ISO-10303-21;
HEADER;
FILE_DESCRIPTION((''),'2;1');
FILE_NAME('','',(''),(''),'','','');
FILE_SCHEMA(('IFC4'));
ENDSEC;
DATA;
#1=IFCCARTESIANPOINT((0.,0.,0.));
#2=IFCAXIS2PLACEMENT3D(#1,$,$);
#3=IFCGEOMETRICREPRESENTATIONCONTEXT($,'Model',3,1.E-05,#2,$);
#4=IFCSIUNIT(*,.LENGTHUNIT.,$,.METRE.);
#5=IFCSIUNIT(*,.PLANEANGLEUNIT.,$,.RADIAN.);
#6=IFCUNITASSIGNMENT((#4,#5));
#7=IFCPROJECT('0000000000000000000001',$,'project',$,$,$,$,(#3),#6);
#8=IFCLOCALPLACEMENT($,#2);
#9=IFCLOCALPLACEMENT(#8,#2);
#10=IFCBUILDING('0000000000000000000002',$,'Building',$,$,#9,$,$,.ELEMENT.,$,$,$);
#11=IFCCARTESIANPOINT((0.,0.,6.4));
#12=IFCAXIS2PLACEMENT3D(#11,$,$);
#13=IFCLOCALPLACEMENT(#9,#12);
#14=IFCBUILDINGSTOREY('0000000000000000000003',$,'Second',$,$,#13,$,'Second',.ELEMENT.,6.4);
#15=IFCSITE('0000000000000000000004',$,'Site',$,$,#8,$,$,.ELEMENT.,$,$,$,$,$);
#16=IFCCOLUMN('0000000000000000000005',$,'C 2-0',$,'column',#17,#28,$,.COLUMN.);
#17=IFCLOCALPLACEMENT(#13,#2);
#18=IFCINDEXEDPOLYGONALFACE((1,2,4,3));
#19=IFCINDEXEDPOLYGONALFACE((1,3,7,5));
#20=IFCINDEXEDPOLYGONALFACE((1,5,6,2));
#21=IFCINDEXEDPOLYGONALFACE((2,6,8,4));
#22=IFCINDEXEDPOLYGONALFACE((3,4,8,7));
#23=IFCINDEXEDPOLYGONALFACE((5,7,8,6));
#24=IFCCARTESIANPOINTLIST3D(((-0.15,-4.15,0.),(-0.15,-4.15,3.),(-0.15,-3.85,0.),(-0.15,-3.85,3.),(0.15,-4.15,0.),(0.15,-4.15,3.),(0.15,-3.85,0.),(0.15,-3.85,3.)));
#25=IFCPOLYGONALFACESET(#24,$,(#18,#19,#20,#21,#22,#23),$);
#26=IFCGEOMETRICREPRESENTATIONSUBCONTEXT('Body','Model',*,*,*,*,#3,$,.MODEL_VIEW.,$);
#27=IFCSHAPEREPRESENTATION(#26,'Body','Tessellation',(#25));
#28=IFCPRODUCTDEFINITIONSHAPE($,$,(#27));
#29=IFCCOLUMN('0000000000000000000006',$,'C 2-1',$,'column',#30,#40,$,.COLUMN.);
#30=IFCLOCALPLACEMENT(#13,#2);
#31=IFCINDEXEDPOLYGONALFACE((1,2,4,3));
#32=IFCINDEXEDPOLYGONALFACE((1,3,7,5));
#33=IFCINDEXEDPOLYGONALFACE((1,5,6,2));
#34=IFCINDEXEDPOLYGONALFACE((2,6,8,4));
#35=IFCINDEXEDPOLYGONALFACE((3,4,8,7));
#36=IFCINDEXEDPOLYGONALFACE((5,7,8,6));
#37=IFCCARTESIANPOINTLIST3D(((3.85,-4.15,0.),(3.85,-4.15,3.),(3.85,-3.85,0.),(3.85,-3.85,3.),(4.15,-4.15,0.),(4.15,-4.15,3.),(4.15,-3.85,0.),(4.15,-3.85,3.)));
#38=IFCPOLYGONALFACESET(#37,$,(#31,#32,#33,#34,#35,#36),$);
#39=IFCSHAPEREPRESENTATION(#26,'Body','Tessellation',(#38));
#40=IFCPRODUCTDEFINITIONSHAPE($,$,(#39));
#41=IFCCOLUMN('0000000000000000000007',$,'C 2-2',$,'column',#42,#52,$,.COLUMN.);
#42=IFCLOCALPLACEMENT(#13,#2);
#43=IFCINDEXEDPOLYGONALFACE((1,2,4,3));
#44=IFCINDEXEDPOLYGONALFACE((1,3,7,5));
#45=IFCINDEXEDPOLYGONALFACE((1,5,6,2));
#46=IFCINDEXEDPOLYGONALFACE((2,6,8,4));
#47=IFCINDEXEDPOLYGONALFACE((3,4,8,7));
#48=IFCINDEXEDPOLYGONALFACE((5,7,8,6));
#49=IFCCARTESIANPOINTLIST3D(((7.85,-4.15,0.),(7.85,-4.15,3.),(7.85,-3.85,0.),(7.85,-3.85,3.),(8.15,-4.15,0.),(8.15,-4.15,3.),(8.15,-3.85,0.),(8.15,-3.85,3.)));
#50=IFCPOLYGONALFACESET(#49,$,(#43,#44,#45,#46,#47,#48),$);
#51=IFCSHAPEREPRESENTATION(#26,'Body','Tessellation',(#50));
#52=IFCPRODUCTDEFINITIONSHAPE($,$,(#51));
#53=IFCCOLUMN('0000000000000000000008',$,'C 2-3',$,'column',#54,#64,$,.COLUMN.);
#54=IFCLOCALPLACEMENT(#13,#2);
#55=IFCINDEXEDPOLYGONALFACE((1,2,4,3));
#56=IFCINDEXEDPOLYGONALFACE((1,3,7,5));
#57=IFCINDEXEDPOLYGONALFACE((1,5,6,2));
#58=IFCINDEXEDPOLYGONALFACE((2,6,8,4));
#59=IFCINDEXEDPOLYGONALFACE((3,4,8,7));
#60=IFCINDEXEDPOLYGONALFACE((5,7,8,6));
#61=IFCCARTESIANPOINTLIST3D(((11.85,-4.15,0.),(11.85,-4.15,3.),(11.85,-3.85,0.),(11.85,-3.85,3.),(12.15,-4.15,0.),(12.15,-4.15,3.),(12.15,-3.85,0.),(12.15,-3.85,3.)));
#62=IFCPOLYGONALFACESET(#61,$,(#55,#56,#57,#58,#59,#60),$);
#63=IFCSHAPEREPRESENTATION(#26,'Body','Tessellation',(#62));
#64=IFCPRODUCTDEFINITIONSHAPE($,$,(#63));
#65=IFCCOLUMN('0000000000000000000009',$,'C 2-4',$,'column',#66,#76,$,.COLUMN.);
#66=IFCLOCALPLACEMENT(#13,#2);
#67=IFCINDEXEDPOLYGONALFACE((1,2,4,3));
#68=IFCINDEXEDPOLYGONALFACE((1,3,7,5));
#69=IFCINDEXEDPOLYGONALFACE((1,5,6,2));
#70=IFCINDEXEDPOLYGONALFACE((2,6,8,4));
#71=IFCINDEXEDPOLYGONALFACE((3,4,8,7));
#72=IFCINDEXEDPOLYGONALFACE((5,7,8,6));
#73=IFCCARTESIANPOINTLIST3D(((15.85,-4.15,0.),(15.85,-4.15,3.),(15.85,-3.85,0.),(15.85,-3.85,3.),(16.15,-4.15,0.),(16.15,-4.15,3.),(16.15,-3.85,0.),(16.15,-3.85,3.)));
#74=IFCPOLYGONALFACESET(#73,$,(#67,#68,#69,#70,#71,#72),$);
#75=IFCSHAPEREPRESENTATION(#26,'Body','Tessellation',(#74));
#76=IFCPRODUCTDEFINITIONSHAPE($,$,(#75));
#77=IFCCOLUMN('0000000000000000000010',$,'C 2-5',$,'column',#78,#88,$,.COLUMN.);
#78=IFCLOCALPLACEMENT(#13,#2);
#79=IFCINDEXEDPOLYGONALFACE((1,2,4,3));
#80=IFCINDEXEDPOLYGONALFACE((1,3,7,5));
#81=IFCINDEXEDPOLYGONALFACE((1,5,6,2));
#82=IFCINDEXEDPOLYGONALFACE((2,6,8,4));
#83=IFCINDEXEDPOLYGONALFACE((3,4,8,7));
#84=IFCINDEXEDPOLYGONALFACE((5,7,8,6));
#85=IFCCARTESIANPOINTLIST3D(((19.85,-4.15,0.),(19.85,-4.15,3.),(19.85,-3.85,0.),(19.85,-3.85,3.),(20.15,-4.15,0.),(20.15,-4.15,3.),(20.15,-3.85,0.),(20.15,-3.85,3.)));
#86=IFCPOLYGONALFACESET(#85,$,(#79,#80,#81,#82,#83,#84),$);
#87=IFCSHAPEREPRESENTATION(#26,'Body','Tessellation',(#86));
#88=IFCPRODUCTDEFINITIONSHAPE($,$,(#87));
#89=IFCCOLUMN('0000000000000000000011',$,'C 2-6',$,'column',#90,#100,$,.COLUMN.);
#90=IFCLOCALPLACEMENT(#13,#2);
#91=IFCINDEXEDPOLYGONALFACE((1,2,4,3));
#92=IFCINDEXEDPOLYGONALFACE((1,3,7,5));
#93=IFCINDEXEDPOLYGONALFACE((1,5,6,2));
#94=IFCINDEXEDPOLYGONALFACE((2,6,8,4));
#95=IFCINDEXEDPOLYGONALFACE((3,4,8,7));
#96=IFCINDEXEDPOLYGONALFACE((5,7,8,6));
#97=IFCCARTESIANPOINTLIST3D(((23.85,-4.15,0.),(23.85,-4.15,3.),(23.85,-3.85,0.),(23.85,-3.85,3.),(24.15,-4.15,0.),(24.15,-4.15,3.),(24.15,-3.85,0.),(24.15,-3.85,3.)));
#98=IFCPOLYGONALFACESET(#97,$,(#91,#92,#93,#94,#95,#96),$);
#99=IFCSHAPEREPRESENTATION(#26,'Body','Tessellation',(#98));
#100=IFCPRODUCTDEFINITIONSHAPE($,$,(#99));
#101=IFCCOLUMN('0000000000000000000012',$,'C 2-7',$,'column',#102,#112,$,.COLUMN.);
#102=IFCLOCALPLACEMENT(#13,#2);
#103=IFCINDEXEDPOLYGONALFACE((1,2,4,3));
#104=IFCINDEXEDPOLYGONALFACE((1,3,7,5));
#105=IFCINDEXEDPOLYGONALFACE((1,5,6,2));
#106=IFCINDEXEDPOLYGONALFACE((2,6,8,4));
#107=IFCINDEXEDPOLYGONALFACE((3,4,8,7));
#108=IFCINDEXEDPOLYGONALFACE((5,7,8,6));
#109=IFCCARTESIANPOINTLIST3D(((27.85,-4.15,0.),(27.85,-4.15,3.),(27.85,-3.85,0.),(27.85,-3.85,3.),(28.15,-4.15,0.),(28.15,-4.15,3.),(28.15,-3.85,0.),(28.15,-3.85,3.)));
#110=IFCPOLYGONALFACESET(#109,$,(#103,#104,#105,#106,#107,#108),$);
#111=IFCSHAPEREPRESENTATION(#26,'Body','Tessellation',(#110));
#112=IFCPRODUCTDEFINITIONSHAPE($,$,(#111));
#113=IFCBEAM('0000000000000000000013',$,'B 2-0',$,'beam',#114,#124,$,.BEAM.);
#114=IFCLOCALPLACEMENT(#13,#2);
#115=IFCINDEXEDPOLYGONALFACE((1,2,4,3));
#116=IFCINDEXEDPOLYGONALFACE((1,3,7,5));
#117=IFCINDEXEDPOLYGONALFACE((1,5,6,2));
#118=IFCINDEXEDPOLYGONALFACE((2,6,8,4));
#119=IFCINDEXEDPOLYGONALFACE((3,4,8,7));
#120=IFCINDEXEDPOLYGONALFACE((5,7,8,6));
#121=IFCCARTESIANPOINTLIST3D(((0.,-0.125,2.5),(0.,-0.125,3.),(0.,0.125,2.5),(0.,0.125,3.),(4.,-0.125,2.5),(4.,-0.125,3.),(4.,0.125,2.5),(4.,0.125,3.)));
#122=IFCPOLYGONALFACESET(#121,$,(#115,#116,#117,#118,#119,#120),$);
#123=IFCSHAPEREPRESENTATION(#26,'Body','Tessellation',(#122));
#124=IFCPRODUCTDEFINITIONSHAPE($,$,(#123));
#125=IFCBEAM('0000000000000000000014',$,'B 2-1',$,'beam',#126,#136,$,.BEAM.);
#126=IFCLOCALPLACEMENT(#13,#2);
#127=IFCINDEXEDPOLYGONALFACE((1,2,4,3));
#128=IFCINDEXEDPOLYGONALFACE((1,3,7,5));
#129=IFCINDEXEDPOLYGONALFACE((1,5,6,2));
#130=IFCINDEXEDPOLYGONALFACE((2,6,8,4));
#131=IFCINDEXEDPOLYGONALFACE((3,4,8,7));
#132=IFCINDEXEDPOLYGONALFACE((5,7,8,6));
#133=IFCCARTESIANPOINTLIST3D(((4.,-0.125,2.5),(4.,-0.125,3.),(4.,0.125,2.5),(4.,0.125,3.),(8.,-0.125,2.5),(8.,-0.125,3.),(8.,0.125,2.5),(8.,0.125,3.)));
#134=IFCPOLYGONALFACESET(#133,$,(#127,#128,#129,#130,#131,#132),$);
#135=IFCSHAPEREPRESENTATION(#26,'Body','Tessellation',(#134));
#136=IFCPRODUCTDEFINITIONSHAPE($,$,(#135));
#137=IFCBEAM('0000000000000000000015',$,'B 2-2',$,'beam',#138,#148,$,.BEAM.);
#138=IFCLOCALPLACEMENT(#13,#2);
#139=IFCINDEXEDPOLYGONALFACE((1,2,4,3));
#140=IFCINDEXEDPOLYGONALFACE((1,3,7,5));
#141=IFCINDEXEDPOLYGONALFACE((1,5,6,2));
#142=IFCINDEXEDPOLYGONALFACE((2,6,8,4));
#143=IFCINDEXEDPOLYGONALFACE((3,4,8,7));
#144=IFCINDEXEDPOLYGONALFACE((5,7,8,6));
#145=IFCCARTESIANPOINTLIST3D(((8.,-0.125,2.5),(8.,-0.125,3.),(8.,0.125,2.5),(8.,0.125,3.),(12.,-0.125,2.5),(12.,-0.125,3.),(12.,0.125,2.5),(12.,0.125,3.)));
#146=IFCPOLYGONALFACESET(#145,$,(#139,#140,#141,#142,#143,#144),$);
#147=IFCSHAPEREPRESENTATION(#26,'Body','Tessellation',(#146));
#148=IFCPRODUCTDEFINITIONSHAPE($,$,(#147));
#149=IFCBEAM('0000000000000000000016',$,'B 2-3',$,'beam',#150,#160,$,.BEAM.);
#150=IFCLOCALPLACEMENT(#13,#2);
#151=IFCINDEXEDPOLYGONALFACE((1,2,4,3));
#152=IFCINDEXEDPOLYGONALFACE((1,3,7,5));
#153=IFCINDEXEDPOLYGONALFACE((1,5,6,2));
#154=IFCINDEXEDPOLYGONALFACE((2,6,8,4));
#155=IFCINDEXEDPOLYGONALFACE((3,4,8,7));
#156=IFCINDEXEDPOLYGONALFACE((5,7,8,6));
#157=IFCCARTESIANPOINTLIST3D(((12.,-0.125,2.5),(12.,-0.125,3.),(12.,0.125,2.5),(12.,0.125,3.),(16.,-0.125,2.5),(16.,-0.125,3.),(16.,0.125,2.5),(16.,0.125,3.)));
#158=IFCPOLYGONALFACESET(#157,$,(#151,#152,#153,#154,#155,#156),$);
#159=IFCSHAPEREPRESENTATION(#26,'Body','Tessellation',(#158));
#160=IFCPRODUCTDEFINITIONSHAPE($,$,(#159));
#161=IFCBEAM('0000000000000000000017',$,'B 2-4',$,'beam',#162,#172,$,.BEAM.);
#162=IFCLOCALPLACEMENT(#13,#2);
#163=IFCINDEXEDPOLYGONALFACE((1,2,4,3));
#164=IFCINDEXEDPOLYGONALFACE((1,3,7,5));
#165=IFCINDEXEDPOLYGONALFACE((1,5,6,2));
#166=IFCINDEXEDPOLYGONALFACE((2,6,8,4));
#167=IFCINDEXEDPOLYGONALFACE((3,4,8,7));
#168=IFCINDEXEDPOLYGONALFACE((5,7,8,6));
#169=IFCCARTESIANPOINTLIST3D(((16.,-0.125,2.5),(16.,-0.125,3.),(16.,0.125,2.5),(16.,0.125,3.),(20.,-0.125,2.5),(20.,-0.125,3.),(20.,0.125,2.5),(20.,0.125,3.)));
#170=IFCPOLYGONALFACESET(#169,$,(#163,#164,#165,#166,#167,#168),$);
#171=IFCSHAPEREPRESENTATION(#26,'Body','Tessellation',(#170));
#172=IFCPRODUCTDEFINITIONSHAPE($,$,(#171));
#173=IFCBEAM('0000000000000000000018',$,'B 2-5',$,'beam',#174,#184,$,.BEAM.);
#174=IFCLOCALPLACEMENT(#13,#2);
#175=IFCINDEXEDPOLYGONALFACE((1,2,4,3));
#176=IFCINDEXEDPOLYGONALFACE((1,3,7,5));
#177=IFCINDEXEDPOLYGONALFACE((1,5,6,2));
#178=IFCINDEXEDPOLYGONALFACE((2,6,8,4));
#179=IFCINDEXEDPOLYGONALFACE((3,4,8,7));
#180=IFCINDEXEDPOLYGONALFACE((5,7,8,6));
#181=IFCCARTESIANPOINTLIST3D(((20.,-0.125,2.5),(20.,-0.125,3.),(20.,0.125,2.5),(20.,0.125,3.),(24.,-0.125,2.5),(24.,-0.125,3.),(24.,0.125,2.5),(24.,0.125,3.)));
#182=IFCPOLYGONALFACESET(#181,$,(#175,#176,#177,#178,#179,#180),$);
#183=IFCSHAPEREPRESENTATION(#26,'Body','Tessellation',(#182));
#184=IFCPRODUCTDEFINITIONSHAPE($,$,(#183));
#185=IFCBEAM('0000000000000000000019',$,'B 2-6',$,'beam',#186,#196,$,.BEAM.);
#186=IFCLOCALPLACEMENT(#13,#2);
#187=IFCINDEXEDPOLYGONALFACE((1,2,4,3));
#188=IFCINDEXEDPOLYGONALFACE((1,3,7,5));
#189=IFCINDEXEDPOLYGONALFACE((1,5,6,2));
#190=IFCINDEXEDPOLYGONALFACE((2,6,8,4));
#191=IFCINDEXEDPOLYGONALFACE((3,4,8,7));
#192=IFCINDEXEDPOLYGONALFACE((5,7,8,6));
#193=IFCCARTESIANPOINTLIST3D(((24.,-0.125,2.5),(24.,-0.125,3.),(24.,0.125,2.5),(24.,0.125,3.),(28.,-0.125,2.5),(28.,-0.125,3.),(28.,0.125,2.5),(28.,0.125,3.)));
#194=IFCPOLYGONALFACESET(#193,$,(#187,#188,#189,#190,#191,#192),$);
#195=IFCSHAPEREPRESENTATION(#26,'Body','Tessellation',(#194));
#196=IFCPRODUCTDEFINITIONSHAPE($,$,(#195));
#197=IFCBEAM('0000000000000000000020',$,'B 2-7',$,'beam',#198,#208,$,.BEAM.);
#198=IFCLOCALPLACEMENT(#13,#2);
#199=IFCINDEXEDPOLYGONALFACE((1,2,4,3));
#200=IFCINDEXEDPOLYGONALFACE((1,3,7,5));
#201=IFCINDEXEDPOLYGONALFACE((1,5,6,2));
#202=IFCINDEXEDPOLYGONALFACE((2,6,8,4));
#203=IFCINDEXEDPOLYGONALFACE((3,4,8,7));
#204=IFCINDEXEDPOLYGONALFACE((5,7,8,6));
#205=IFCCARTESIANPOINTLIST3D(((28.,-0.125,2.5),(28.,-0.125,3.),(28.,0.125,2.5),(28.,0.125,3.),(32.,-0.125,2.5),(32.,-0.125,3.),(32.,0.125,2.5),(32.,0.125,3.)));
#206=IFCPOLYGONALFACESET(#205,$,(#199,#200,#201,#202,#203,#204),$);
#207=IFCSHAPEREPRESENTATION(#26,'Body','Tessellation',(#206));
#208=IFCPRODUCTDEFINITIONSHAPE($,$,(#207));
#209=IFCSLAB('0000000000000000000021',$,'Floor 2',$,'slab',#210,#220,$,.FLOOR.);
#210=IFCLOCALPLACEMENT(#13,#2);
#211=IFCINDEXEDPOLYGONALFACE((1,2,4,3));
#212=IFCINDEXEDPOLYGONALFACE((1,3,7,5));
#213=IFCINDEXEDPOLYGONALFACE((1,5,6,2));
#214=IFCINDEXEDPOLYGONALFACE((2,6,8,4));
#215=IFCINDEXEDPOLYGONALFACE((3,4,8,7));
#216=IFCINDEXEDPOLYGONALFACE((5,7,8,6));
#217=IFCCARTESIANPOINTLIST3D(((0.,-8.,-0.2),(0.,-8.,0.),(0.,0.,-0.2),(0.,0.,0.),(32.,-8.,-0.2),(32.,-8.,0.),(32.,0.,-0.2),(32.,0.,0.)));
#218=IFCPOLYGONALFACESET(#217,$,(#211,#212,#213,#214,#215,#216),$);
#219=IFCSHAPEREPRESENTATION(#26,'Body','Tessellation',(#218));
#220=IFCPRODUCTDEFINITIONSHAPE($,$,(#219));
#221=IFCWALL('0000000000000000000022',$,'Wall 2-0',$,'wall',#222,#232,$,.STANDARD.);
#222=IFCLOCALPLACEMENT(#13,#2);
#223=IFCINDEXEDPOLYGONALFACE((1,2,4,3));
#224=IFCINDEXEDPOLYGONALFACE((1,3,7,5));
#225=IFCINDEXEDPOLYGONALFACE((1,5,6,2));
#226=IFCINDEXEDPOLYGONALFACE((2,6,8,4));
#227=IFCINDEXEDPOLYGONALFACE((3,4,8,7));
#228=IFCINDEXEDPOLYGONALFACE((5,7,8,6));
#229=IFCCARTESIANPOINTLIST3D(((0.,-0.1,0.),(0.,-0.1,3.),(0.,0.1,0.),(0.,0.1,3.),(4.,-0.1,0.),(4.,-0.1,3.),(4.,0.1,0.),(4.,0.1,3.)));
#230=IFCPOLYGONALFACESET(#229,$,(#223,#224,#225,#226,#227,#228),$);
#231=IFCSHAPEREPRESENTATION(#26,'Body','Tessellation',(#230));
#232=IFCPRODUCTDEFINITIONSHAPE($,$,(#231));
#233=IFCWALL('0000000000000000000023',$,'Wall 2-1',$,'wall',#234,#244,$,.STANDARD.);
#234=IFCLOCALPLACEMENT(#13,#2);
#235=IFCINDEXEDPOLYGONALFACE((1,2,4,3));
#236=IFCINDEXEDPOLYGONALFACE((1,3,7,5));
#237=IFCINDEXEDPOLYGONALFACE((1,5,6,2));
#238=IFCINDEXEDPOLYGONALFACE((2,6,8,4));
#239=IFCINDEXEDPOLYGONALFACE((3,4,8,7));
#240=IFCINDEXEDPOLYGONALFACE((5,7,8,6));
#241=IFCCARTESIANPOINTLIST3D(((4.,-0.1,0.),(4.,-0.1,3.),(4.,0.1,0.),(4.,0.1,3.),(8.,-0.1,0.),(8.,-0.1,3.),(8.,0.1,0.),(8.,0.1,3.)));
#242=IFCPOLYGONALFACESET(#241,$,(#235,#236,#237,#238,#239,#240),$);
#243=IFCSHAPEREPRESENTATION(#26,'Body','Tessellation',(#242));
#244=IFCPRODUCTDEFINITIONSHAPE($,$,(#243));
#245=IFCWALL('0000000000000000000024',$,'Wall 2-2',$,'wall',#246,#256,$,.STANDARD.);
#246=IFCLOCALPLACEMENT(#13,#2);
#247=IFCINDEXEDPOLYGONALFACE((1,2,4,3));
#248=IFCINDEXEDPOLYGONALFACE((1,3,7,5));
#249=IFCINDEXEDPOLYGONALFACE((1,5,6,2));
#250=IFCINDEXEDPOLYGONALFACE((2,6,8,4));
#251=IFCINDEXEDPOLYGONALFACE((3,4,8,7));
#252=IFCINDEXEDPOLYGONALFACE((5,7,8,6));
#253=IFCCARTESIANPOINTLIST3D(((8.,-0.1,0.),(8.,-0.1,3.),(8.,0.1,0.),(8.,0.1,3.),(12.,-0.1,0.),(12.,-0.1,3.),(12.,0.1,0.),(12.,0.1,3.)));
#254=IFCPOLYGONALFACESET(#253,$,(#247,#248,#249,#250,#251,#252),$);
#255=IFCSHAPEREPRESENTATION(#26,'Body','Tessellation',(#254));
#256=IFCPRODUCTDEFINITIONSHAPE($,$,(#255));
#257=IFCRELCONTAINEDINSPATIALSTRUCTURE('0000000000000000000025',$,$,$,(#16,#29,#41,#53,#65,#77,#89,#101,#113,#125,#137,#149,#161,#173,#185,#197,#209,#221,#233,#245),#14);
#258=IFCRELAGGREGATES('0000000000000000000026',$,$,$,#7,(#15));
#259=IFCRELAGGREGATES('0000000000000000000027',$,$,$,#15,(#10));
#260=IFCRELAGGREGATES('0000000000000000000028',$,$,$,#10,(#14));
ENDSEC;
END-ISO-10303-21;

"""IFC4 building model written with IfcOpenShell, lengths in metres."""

from ifc_helpers import new_model, si_unit, frame, frame_2d, origin, origin_2d, place, context, subcontext, project, spatial, polyline, rectangle, outline, extrude, element, save


model = new_model("IFC4")

# Units and contexts
model_context = context("Model", 3, precision=1e-05, world=origin())
body_context = subcontext(model_context, "Body", "Model", "MODEL_VIEW")
ifc_project = project(units=[si_unit("LENGTHUNIT", "METRE"), si_unit("PLANEANGLEUNIT", "RADIAN")], contexts=[model_context])

# Site, building, storey
site_placement = place(None, origin())
site = spatial("IfcSite", under=ifc_project, at=site_placement, Name="Site", CompositionType="ELEMENT")
building_placement = place(site_placement, origin())
building = spatial("IfcBuilding", under=site, at=building_placement, Name="Building", CompositionType="ELEMENT")
storey_placement = place(building_placement, frame((0.0, 0.0, 6.4)))
storey = spatial("IfcBuildingStorey", under=building, at=storey_placement, Name="Second", LongName="Second", CompositionType="ELEMENT", Elevation=6.4)

# Columns
for number, where, name in (
    (1, (0.0, -4.0, 0.0), "C 2-0"),
    (2, (4.0, -4.0, 0.0), "C 2-1"),
    (3, (8.0, -4.0, 0.0), "C 2-2"),
    (4, (12.0, -4.0, 0.0), "C 2-3"),
    (5, (16.0, -4.0, 0.0), "C 2-4"),
    (6, (20.0, -4.0, 0.0), "C 2-5"),
    (7, (24.0, -4.0, 0.0), "C 2-6"),
    (8, (28.0, -4.0, 0.0), "C 2-7"),
):
    element("IfcColumn", number, at=place(storey_placement, frame(where)), inside=storey, Name=name, ObjectType="column", PredefinedType="COLUMN", context=body_context, shape_type="SweptSolid", body=[
        extrude(rectangle(XDim=0.3, YDim=0.3, at=origin_2d()), origin(), (0.0, 0.0, 1.0), 3.0),
    ])

# Beams
for number, where, z_axis, x_axis, name in (
    (9, (0.0, 0.0, 2.75), (1.0, 0.0, 0.0), (0.0, 0.0, 1.0), "B 2-0"),
    (10, (4.0, 0.0, 2.75), (1.0, 0.0, 0.0), (0.0, 0.0, 1.0), "B 2-1"),
    (11, (8.0, 0.0, 2.75), (1.0, 0.0, 0.0), (0.0, 0.0, 1.0), "B 2-2"),
    (12, (12.0, 0.0, 2.75), (1.0, 0.0, 0.0), (0.0, 0.0, 1.0), "B 2-3"),
    (13, (16.0, 0.0, 2.75), (1.0, 0.0, 0.0), (0.0, 0.0, 1.0), "B 2-4"),
    (14, (20.0, 0.0, 2.75), (1.0, 0.0, 0.0), (0.0, 0.0, 1.0), "B 2-5"),
    (15, (24.0, 0.0, 2.75), (1.0, 0.0, 0.0), (0.0, 0.0, 1.0), "B 2-6"),
    (16, (28.0, 0.0, 2.75), (1.0, 0.0, 0.0), (0.0, 0.0, 1.0), "B 2-7"),
):
    element("IfcBeam", number, at=place(storey_placement, frame(where, z_axis=z_axis, x_axis=x_axis)), inside=storey, Name=name, ObjectType="beam", PredefinedType="BEAM", context=body_context, shape_type="SweptSolid", body=[
        extrude(rectangle(XDim=0.5, YDim=0.25, at=origin_2d()), origin(), (0.0, 0.0, 1.0), 4.0),
    ])

# Slab
slab_placement = place(storey_placement, frame((0.0, 0.0, -0.2)))
element("IfcSlab", 17, at=slab_placement, inside=storey, Name="Floor 2", ObjectType="slab", PredefinedType="FLOOR", context=body_context, shape_type="SweptSolid", body=[
    extrude(outline(polyline([(0.0, -8.0), (32.0, -8.0), (32.0, 0.0), (0.0, 0.0), (0.0, -8.0)])), origin(), (0.0, 0.0, 1.0), 0.2),
])

# Walls
for number, where, z_axis, x_axis, name in (
    (18, (0.0, 0.0, 0.0), (0.0, 0.0, 1.0), (1.0, 0.0, 0.0), "Wall 2-0"),
    (19, (4.0, 0.0, 0.0), (0.0, 0.0, 1.0), (1.0, 0.0, 0.0), "Wall 2-1"),
    (20, (8.0, 0.0, 0.0), (0.0, 0.0, 1.0), (1.0, 0.0, 0.0), "Wall 2-2"),
):
    element("IfcWall", number, at=place(storey_placement, frame(where, z_axis=z_axis, x_axis=x_axis)), inside=storey, Name=name, ObjectType="wall", PredefinedType="STANDARD", context=body_context, shape_type="SweptSolid", body=[
        extrude(rectangle(XDim=4.0, YDim=0.2, at=frame_2d((2.0, 0.0))), origin(), (0.0, 0.0, 1.0), 3.0),
    ])

save(model, "model.ifc")
